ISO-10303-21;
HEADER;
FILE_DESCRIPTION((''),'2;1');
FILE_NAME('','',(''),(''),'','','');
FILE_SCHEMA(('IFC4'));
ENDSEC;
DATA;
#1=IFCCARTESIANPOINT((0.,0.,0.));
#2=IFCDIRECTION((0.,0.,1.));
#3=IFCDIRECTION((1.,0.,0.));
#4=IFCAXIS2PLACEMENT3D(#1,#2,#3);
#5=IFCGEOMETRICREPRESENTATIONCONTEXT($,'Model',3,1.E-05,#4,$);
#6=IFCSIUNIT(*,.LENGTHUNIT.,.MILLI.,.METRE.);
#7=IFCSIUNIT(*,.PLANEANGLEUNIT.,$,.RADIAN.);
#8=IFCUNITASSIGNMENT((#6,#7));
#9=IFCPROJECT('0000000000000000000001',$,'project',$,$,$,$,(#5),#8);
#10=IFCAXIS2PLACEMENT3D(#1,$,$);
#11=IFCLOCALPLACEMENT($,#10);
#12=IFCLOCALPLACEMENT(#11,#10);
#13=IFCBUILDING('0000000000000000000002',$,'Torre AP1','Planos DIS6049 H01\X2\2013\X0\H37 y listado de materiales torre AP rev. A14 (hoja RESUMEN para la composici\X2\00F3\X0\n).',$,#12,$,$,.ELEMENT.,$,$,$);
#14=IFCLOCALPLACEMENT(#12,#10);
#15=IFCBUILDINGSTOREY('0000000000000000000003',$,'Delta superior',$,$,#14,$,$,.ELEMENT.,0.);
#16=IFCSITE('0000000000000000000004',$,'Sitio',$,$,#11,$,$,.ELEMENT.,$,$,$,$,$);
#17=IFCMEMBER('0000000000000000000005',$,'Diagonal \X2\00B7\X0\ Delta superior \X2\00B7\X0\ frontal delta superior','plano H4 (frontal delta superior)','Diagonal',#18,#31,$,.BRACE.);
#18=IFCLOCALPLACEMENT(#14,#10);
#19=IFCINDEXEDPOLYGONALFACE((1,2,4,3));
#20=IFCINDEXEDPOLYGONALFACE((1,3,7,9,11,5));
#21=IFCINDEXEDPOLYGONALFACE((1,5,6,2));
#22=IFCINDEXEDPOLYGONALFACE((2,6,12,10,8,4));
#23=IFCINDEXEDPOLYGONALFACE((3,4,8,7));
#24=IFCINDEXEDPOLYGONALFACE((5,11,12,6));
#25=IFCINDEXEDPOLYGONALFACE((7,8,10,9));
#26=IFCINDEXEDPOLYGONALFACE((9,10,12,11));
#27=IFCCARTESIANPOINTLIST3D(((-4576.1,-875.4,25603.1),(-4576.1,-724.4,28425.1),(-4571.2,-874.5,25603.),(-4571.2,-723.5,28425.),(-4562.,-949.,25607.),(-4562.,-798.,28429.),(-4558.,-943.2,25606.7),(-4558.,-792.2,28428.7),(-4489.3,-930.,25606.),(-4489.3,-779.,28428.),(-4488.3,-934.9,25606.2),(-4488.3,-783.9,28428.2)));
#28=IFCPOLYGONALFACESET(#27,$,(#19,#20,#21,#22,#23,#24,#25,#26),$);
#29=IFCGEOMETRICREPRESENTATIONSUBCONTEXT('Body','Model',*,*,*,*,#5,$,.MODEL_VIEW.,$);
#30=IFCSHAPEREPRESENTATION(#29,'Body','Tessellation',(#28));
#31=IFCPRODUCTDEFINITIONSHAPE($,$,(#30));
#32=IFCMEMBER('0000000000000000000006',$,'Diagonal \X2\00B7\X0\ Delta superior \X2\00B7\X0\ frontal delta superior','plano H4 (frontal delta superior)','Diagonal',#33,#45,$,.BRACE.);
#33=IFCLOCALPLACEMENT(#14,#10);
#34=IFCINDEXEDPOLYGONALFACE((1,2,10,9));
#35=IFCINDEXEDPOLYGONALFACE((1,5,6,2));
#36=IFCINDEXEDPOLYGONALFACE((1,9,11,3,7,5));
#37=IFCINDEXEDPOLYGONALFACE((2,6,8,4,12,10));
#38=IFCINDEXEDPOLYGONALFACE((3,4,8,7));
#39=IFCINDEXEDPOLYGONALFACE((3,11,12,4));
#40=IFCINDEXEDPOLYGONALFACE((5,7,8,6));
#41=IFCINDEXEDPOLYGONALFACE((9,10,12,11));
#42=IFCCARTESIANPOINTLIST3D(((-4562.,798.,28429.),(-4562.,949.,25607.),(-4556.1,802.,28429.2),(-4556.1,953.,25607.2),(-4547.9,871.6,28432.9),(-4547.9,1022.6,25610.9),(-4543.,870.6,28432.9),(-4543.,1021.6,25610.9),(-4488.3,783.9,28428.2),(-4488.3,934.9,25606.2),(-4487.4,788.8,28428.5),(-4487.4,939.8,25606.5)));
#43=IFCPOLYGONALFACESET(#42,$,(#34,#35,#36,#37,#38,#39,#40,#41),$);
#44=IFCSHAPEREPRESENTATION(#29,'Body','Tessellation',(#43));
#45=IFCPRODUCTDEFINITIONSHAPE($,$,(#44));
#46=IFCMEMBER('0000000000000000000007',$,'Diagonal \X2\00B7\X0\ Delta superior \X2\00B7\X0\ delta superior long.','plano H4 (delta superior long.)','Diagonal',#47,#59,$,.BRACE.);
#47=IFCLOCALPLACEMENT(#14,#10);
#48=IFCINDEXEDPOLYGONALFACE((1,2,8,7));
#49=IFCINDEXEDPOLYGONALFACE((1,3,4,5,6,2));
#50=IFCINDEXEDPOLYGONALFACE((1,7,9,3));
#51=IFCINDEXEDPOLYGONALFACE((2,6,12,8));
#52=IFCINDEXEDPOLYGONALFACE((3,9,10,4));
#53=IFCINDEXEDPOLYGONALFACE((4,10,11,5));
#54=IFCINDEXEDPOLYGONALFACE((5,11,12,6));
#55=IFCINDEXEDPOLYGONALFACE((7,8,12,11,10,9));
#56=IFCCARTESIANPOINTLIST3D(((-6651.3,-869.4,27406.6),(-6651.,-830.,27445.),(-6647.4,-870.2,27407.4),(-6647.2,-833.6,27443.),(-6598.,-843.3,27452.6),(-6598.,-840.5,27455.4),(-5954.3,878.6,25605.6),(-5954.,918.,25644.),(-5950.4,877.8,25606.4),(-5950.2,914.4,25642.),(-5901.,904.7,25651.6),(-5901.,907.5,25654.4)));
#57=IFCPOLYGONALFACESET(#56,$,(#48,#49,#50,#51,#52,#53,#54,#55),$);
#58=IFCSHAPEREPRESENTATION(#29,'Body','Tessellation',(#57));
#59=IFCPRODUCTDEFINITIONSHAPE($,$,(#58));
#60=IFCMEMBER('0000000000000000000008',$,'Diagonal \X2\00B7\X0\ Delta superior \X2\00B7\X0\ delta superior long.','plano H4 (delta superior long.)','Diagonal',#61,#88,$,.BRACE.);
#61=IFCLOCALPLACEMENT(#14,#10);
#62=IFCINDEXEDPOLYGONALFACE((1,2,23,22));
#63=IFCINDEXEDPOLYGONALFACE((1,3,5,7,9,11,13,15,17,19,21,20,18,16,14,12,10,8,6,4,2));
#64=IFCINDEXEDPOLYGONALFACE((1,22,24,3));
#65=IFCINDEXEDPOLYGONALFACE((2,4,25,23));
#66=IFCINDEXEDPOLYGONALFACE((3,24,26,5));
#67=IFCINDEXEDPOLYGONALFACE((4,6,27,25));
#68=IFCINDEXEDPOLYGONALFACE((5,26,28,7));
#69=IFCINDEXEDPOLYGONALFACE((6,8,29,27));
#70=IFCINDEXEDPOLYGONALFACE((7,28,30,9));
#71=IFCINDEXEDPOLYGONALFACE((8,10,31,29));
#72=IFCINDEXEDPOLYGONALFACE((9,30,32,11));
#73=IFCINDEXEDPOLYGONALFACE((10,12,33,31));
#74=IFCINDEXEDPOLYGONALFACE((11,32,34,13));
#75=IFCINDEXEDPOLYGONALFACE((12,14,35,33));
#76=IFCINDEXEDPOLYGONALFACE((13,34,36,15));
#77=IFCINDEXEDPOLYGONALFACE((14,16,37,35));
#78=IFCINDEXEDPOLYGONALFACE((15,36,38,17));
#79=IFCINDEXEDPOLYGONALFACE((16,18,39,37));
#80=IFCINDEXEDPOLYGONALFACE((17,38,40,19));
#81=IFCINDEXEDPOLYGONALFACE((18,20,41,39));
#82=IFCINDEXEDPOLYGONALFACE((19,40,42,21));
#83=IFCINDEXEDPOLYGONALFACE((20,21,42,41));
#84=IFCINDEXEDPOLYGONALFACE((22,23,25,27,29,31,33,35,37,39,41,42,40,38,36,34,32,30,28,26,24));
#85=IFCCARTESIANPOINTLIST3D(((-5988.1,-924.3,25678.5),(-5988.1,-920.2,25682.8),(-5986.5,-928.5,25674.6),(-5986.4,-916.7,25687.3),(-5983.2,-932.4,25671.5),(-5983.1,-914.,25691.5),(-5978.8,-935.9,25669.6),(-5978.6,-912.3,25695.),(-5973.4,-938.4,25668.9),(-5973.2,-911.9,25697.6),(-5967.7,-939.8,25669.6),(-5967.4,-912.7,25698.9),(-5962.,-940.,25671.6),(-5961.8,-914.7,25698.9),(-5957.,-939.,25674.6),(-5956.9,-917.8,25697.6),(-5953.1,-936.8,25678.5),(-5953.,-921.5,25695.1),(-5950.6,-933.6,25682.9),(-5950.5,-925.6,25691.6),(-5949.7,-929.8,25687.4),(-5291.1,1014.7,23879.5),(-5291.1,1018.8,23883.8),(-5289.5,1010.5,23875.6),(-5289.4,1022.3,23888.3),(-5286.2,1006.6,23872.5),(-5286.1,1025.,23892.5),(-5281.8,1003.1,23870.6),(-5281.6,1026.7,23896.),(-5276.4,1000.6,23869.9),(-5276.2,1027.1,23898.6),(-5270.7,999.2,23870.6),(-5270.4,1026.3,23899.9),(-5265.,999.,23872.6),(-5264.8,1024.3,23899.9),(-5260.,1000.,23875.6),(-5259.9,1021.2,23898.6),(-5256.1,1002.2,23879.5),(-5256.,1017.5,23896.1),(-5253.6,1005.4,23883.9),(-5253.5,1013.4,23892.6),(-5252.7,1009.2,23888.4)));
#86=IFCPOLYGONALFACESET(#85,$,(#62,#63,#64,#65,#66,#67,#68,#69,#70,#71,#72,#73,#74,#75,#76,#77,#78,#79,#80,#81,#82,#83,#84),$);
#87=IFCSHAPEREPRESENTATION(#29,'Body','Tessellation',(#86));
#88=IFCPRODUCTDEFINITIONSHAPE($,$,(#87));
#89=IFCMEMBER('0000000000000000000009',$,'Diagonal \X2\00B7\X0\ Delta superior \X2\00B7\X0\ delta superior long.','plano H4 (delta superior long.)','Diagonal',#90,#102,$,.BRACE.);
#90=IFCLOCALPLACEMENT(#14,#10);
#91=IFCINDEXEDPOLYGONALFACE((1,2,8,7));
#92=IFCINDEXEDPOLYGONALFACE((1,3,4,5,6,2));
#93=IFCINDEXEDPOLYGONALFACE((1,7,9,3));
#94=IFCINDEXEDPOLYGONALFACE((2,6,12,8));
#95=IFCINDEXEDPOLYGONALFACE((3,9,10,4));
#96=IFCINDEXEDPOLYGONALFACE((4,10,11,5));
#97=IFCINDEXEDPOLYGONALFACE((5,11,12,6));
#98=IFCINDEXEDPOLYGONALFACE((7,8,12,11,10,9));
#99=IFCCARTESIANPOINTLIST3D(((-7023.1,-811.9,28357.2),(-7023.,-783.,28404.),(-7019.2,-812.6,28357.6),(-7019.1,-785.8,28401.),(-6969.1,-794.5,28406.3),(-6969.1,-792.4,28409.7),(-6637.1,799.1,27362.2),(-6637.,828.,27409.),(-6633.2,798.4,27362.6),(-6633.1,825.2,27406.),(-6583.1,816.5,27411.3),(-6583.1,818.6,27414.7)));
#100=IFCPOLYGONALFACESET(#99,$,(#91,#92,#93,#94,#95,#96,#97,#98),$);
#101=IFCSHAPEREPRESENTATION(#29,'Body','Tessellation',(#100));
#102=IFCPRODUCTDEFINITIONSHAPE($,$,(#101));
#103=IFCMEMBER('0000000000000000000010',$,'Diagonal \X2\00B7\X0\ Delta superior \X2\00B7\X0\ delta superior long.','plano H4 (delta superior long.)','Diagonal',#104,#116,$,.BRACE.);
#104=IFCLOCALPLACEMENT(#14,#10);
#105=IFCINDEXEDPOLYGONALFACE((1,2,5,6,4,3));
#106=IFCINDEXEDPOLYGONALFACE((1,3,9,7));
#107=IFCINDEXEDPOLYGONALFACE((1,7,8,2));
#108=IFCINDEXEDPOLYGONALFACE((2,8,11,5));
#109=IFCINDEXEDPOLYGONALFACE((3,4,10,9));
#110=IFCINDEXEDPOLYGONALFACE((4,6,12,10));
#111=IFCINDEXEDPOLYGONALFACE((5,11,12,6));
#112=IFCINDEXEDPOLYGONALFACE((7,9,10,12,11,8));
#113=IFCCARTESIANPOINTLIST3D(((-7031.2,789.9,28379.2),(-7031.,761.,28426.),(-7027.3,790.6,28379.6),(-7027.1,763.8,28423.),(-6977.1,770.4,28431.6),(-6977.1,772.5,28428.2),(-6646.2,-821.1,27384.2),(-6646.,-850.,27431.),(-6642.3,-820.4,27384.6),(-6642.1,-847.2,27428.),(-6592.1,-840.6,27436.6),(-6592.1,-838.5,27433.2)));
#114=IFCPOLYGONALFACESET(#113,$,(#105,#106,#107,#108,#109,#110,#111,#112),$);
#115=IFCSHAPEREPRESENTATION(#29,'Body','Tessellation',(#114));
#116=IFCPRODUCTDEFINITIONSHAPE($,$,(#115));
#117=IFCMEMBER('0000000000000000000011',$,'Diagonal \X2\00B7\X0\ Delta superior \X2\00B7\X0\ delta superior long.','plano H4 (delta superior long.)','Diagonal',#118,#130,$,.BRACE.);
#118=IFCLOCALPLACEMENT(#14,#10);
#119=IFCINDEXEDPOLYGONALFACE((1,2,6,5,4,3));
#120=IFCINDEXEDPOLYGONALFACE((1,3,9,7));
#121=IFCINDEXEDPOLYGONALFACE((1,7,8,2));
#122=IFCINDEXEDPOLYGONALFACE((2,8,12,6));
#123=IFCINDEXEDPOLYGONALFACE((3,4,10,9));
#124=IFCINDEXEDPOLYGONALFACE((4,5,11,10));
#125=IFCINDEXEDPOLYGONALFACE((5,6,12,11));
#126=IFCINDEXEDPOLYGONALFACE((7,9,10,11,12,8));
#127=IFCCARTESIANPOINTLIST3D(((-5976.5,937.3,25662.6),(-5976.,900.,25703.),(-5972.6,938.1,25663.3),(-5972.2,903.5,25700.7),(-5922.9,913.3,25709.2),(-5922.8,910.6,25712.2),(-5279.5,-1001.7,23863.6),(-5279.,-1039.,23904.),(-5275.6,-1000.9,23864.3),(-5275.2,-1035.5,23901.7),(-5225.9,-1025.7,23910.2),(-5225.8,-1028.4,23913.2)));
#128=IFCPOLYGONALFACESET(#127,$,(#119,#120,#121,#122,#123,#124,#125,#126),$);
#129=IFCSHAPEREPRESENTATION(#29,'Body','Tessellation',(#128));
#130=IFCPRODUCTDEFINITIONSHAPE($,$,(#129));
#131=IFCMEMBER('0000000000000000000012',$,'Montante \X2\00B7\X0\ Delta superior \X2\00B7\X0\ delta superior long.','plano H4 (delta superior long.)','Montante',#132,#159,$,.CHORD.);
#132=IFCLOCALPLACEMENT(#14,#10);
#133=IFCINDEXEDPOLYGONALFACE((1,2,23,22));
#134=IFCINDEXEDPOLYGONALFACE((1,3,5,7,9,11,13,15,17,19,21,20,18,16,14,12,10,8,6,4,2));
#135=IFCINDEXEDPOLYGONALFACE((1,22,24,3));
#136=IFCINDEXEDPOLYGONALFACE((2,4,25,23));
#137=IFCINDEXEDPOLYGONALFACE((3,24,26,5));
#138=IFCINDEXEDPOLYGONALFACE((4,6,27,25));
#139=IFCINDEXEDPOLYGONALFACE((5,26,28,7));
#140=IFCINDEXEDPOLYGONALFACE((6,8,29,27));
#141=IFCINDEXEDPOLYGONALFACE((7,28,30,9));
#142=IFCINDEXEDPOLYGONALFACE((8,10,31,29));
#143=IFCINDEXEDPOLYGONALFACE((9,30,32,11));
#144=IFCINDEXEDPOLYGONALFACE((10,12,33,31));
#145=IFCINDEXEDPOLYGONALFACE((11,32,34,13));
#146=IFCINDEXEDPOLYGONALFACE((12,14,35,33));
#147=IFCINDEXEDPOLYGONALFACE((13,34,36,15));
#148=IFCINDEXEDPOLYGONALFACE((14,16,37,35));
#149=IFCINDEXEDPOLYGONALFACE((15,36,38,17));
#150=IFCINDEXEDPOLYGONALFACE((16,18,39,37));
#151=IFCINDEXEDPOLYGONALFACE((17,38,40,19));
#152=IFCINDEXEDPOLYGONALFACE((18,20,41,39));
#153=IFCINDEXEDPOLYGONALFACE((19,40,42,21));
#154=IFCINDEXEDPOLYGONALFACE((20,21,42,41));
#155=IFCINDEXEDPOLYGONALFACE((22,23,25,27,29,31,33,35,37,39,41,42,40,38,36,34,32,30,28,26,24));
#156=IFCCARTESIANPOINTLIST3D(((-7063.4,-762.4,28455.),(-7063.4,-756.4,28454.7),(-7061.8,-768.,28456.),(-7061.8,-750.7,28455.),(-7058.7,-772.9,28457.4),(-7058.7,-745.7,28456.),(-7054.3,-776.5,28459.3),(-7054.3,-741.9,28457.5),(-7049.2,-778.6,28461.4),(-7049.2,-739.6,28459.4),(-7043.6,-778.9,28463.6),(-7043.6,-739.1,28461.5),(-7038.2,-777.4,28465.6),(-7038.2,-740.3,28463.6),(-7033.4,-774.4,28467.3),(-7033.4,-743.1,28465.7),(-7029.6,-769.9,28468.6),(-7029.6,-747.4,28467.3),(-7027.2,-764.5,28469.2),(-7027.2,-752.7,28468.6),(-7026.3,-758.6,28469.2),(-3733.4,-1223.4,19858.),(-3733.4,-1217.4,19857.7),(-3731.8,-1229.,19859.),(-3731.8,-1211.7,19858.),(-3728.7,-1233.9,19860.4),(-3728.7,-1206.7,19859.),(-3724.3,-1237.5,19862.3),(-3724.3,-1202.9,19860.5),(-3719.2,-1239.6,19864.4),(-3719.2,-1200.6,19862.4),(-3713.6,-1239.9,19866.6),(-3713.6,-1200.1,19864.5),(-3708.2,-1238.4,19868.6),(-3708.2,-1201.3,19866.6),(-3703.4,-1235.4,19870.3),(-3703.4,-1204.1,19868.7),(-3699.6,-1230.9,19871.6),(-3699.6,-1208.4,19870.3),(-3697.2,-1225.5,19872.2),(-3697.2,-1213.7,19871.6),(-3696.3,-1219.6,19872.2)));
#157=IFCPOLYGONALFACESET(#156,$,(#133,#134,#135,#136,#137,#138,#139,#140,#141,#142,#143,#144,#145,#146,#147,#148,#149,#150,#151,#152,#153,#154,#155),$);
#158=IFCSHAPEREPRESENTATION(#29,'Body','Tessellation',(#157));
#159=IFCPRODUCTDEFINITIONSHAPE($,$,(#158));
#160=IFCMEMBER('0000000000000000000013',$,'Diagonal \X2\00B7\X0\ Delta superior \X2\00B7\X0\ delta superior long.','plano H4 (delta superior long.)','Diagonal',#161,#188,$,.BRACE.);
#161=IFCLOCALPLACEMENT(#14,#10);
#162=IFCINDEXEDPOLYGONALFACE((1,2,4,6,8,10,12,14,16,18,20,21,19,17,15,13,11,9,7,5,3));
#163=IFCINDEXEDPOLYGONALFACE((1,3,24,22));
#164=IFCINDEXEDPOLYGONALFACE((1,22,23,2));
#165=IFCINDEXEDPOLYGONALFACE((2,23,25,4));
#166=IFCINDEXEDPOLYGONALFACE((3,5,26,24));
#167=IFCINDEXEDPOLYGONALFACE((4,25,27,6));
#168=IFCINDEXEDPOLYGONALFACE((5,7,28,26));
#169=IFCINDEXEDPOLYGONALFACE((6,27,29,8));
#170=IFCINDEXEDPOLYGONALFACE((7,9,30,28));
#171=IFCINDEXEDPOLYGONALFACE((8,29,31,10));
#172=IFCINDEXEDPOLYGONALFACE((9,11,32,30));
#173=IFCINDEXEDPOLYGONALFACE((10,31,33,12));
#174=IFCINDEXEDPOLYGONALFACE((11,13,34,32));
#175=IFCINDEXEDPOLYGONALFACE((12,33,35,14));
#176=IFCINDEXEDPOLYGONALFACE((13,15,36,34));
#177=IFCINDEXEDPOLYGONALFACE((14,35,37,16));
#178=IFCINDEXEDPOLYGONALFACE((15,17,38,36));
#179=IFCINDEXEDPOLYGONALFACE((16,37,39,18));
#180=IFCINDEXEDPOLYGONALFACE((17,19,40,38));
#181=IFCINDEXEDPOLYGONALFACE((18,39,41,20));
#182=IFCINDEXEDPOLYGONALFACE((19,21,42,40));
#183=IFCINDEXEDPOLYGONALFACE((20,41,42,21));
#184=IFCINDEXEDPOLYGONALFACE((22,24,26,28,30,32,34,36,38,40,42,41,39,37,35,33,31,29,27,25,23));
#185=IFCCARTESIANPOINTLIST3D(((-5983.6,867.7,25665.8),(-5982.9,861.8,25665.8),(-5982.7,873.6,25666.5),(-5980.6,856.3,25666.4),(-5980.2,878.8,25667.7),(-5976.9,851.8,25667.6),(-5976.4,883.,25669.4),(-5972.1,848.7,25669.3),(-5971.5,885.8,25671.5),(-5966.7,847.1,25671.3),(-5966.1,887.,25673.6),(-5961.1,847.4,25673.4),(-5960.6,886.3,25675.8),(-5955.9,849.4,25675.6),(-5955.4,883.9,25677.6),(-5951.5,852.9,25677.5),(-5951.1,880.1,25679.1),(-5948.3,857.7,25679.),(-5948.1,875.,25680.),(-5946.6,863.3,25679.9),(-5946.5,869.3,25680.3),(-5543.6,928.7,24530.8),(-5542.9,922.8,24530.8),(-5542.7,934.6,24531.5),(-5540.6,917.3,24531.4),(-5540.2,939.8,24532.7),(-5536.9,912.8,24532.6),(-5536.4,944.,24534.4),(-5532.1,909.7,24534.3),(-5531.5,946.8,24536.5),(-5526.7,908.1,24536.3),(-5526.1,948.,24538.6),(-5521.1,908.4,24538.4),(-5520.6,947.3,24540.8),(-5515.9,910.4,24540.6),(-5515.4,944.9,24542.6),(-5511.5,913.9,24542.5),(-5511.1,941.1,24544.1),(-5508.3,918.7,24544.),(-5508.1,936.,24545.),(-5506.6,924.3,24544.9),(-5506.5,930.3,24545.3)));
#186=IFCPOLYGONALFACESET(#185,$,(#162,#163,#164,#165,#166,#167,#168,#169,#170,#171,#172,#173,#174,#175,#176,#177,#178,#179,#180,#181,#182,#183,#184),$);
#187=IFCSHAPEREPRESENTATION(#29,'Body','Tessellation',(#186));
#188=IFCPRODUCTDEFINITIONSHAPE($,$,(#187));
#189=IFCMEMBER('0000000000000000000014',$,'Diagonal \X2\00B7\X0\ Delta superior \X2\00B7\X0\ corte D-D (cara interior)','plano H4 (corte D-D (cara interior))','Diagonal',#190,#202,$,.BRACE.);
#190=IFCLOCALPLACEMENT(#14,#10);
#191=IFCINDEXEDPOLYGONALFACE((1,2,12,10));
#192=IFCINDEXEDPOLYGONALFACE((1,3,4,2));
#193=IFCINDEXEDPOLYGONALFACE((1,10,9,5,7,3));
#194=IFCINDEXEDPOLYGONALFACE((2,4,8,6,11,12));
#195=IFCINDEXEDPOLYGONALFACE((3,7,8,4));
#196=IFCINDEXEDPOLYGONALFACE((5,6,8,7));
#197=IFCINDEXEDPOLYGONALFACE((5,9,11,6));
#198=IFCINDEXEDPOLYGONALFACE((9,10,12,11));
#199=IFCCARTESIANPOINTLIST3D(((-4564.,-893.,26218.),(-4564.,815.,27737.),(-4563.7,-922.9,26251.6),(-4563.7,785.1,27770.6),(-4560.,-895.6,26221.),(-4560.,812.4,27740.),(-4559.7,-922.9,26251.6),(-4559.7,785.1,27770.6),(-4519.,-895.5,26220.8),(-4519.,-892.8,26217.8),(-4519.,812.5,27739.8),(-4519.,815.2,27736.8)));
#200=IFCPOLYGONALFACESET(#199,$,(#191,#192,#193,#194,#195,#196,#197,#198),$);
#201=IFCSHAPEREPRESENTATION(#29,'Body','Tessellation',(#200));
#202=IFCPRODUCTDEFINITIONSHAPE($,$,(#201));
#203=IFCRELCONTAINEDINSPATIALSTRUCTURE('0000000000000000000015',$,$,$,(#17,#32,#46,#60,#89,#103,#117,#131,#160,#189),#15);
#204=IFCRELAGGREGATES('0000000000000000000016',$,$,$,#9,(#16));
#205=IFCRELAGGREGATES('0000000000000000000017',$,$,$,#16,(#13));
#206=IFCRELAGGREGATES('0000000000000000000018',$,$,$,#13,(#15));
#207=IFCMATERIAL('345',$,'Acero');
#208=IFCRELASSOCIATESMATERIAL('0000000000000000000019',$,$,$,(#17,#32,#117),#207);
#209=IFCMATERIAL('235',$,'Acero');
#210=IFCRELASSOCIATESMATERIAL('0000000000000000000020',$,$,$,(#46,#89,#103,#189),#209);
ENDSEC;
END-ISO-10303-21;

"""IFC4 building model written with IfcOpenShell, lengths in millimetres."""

from ifc_helpers import new_model, si_unit, frame, frame_2d, origin, origin_with_axes, place, context, subcontext, project, spatial, circle, l_section, extrude, material, element, save


model = new_model("IFC4")

# Units and contexts
model_context = context("Model", 3, precision=1e-05, world=origin_with_axes())
body_context = subcontext(model_context, "Body", "Model", "MODEL_VIEW")
ifc_project = project(units=[si_unit("LENGTHUNIT", "METRE", prefix="MILLI"), si_unit("PLANEANGLEUNIT", "RADIAN")], contexts=[model_context])

# Site, building, storey
site_placement = place(None, origin())
site = spatial("IfcSite", under=ifc_project, at=site_placement, Name="Sitio", CompositionType="ELEMENT")
building_placement = place(site_placement, origin())
building = spatial("IfcBuilding", under=site, at=building_placement, Name="Torre AP1", Description="Planos DIS6049 H01–H37 y listado de materiales torre AP rev. A14 (hoja RESUMEN para la composición).", CompositionType="ELEMENT")
storey_placement = place(building_placement, origin())
storey = spatial("IfcBuildingStorey", under=building, at=storey_placement, Name="Delta superior", CompositionType="ELEMENT", Elevation=0.0)

# Members
ifc_material_1 = material(Name="235", Category="Acero")
ifc_material_2 = material(Name="345", Category="Acero")
for number, where, z_axis, x_axis, name in (
    (1, (-4562.0, -949.0, 25607.0), (0.0, 0.053432, 0.998572), (0.982208, 0.187529, -0.010034), "Diagonal · Delta superior · frontal delta superior"),
    (2, (-4562.0, 949.0, 25607.0), (0.0, -0.053432, 0.998572), (0.982208, -0.187529, -0.010034), "Diagonal · Delta superior · frontal delta superior"),
):
    element("IfcMember", number, at=place(storey_placement, frame(where, z_axis=z_axis, x_axis=x_axis)), inside=storey, material=ifc_material_2, Name=name, Description="plano H4 (frontal delta superior)", ObjectType="Diagonal", PredefinedType="BRACE", context=body_context, shape_type="SweptSolid", body=[
        extrude(l_section(Depth=75.0, Width=75.0, Thickness=5.0, at=frame_2d((37.5, 37.5))), None, (0.0, 0.0, 1.0), 2826.0),
    ])
member_1_placement = place(storey_placement, frame((-6651.0, -830.0, 27445.0), z_axis=(0.267584, 0.671072, -0.691419), x_axis=(0.963521, -0.190088, 0.188396)))
element("IfcMember", 3, at=member_1_placement, inside=storey, material=ifc_material_1, Name="Diagonal · Delta superior · delta superior long.", Description="plano H4 (delta superior long.)", ObjectType="Diagonal", PredefinedType="BRACE", context=body_context, shape_type="SweptSolid", body=[
    extrude(l_section(Depth=55.0, Width=55.0, Thickness=4.0, at=frame_2d((27.5, 27.5))), None, (0.0, 0.0, 1.0), 2604.8),
])
member_2_placement = place(storey_placement, frame((-5969.0, -926.0, 25684.0), z_axis=(0.254816, 0.708877, -0.657695), x_axis=(0.966975, -0.190493, 0.169325)))
element("IfcMember", 4, at=member_2_placement, inside=storey, Name="Diagonal · Delta superior · delta superior long.", Description="plano H4 (delta superior long.)", ObjectType="Diagonal", PredefinedType="BRACE", context=body_context, shape_type="SweptSolid", body=[
    extrude(circle(Radius=20.0), None, (0.0, 0.0, 1.0), 2735.3),
])
member_3_placement = place(storey_placement, frame((-7023.0, -783.0, 28404.0), z_axis=(0.199747, 0.833659, -0.514892), x_axis=(0.979846, -0.170873, 0.103461)))
element("IfcMember", 5, at=member_3_placement, inside=storey, material=ifc_material_1, Name="Diagonal · Delta superior · delta superior long.", Description="plano H4 (delta superior long.)", ObjectType="Diagonal", PredefinedType="BRACE", context=body_context, shape_type="SweptSolid", body=[
    extrude(l_section(Depth=55.0, Width=55.0, Thickness=4.0, at=frame_2d((27.5, 27.5))), None, (0.0, 0.0, 1.0), 1932.4),
])
member_4_placement = place(storey_placement, frame((-6646.0, -850.0, 27431.0), z_axis=(-0.19925, 0.833745, 0.514945), x_axis=(0.979943, 0.171353, 0.101736)))
element("IfcMember", 6, at=member_4_placement, inside=storey, material=ifc_material_1, Name="Diagonal · Delta superior · delta superior long.", Description="plano H4 (delta superior long.)", ObjectType="Diagonal", PredefinedType="BRACE", context=body_context, shape_type="SweptSolid", body=[
    extrude(l_section(Depth=55.0, Width=55.0, Thickness=4.0, at=frame_2d((27.5, 27.5))), None, (0.0, 0.0, 1.0), 1932.2),
])
member_5_placement = place(storey_placement, frame((-5279.0, -1039.0, 23904.0), z_axis=(-0.254816, 0.708877, 0.657695), x_axis=(0.966953, 0.192686, 0.166953)))
element("IfcMember", 7, at=member_5_placement, inside=storey, material=ifc_material_2, Name="Diagonal · Delta superior · delta superior long.", Description="plano H4 (delta superior long.)", ObjectType="Diagonal", PredefinedType="BRACE", context=body_context, shape_type="SweptSolid", body=[
    extrude(l_section(Depth=55.0, Width=55.0, Thickness=4.0, at=frame_2d((27.5, 27.5))), None, (0.0, 0.0, 1.0), 2735.3),
])
for number, where, z_axis, x_axis, name in (
    (8, (-3715.0, -1220.0, 19865.0), (-0.360744, 0.049941, 0.931327), (0.932665, 0.019317, 0.360227), "Montante · Delta superior · delta superior long."),
):
    element("IfcMember", number, at=place(storey_placement, frame(where, z_axis=z_axis, x_axis=x_axis)), inside=storey, Name=name, Description="plano H4 (delta superior long.)", ObjectType="Montante", PredefinedType="CHORD", context=body_context, shape_type="SweptSolid", body=[
        extrude(circle(Radius=20.0), None, (0.0, 0.0, 1.0), 9230.9),
    ])
member_6_placement = place(storey_placement, frame((-5525.0, 928.0, 24538.0), z_axis=(-0.361002, -0.050048, 0.931221), x_axis=(0.919866, -0.183339, 0.346747)))
element("IfcMember", 9, at=member_6_placement, inside=storey, Name="Diagonal · Delta superior · delta superior long.", Description="plano H4 (delta superior long.)", ObjectType="Diagonal", PredefinedType="BRACE", context=body_context, shape_type="SweptSolid", body=[
    extrude(circle(Radius=20.0), None, (0.0, 0.0, 1.0), 1218.8),
])
member_7_placement = place(storey_placement, frame((-4564.0, 815.0, 27737.0), z_axis=(0.0, -0.74724, -0.664554), x_axis=(0.999984, 0.003774, -0.004243)))
element("IfcMember", 10, at=member_7_placement, inside=storey, material=ifc_material_1, Name="Diagonal · Delta superior · corte D-D (cara interior)", Description="plano H4 (corte D-D (cara interior))", ObjectType="Diagonal", PredefinedType="BRACE", context=body_context, shape_type="SweptSolid", body=[
    extrude(l_section(Depth=45.0, Width=45.0, Thickness=4.0, at=frame_2d((22.5, 22.5))), None, (0.0, 0.0, 1.0), 2285.7),
])

save(model, "model.ifc")
